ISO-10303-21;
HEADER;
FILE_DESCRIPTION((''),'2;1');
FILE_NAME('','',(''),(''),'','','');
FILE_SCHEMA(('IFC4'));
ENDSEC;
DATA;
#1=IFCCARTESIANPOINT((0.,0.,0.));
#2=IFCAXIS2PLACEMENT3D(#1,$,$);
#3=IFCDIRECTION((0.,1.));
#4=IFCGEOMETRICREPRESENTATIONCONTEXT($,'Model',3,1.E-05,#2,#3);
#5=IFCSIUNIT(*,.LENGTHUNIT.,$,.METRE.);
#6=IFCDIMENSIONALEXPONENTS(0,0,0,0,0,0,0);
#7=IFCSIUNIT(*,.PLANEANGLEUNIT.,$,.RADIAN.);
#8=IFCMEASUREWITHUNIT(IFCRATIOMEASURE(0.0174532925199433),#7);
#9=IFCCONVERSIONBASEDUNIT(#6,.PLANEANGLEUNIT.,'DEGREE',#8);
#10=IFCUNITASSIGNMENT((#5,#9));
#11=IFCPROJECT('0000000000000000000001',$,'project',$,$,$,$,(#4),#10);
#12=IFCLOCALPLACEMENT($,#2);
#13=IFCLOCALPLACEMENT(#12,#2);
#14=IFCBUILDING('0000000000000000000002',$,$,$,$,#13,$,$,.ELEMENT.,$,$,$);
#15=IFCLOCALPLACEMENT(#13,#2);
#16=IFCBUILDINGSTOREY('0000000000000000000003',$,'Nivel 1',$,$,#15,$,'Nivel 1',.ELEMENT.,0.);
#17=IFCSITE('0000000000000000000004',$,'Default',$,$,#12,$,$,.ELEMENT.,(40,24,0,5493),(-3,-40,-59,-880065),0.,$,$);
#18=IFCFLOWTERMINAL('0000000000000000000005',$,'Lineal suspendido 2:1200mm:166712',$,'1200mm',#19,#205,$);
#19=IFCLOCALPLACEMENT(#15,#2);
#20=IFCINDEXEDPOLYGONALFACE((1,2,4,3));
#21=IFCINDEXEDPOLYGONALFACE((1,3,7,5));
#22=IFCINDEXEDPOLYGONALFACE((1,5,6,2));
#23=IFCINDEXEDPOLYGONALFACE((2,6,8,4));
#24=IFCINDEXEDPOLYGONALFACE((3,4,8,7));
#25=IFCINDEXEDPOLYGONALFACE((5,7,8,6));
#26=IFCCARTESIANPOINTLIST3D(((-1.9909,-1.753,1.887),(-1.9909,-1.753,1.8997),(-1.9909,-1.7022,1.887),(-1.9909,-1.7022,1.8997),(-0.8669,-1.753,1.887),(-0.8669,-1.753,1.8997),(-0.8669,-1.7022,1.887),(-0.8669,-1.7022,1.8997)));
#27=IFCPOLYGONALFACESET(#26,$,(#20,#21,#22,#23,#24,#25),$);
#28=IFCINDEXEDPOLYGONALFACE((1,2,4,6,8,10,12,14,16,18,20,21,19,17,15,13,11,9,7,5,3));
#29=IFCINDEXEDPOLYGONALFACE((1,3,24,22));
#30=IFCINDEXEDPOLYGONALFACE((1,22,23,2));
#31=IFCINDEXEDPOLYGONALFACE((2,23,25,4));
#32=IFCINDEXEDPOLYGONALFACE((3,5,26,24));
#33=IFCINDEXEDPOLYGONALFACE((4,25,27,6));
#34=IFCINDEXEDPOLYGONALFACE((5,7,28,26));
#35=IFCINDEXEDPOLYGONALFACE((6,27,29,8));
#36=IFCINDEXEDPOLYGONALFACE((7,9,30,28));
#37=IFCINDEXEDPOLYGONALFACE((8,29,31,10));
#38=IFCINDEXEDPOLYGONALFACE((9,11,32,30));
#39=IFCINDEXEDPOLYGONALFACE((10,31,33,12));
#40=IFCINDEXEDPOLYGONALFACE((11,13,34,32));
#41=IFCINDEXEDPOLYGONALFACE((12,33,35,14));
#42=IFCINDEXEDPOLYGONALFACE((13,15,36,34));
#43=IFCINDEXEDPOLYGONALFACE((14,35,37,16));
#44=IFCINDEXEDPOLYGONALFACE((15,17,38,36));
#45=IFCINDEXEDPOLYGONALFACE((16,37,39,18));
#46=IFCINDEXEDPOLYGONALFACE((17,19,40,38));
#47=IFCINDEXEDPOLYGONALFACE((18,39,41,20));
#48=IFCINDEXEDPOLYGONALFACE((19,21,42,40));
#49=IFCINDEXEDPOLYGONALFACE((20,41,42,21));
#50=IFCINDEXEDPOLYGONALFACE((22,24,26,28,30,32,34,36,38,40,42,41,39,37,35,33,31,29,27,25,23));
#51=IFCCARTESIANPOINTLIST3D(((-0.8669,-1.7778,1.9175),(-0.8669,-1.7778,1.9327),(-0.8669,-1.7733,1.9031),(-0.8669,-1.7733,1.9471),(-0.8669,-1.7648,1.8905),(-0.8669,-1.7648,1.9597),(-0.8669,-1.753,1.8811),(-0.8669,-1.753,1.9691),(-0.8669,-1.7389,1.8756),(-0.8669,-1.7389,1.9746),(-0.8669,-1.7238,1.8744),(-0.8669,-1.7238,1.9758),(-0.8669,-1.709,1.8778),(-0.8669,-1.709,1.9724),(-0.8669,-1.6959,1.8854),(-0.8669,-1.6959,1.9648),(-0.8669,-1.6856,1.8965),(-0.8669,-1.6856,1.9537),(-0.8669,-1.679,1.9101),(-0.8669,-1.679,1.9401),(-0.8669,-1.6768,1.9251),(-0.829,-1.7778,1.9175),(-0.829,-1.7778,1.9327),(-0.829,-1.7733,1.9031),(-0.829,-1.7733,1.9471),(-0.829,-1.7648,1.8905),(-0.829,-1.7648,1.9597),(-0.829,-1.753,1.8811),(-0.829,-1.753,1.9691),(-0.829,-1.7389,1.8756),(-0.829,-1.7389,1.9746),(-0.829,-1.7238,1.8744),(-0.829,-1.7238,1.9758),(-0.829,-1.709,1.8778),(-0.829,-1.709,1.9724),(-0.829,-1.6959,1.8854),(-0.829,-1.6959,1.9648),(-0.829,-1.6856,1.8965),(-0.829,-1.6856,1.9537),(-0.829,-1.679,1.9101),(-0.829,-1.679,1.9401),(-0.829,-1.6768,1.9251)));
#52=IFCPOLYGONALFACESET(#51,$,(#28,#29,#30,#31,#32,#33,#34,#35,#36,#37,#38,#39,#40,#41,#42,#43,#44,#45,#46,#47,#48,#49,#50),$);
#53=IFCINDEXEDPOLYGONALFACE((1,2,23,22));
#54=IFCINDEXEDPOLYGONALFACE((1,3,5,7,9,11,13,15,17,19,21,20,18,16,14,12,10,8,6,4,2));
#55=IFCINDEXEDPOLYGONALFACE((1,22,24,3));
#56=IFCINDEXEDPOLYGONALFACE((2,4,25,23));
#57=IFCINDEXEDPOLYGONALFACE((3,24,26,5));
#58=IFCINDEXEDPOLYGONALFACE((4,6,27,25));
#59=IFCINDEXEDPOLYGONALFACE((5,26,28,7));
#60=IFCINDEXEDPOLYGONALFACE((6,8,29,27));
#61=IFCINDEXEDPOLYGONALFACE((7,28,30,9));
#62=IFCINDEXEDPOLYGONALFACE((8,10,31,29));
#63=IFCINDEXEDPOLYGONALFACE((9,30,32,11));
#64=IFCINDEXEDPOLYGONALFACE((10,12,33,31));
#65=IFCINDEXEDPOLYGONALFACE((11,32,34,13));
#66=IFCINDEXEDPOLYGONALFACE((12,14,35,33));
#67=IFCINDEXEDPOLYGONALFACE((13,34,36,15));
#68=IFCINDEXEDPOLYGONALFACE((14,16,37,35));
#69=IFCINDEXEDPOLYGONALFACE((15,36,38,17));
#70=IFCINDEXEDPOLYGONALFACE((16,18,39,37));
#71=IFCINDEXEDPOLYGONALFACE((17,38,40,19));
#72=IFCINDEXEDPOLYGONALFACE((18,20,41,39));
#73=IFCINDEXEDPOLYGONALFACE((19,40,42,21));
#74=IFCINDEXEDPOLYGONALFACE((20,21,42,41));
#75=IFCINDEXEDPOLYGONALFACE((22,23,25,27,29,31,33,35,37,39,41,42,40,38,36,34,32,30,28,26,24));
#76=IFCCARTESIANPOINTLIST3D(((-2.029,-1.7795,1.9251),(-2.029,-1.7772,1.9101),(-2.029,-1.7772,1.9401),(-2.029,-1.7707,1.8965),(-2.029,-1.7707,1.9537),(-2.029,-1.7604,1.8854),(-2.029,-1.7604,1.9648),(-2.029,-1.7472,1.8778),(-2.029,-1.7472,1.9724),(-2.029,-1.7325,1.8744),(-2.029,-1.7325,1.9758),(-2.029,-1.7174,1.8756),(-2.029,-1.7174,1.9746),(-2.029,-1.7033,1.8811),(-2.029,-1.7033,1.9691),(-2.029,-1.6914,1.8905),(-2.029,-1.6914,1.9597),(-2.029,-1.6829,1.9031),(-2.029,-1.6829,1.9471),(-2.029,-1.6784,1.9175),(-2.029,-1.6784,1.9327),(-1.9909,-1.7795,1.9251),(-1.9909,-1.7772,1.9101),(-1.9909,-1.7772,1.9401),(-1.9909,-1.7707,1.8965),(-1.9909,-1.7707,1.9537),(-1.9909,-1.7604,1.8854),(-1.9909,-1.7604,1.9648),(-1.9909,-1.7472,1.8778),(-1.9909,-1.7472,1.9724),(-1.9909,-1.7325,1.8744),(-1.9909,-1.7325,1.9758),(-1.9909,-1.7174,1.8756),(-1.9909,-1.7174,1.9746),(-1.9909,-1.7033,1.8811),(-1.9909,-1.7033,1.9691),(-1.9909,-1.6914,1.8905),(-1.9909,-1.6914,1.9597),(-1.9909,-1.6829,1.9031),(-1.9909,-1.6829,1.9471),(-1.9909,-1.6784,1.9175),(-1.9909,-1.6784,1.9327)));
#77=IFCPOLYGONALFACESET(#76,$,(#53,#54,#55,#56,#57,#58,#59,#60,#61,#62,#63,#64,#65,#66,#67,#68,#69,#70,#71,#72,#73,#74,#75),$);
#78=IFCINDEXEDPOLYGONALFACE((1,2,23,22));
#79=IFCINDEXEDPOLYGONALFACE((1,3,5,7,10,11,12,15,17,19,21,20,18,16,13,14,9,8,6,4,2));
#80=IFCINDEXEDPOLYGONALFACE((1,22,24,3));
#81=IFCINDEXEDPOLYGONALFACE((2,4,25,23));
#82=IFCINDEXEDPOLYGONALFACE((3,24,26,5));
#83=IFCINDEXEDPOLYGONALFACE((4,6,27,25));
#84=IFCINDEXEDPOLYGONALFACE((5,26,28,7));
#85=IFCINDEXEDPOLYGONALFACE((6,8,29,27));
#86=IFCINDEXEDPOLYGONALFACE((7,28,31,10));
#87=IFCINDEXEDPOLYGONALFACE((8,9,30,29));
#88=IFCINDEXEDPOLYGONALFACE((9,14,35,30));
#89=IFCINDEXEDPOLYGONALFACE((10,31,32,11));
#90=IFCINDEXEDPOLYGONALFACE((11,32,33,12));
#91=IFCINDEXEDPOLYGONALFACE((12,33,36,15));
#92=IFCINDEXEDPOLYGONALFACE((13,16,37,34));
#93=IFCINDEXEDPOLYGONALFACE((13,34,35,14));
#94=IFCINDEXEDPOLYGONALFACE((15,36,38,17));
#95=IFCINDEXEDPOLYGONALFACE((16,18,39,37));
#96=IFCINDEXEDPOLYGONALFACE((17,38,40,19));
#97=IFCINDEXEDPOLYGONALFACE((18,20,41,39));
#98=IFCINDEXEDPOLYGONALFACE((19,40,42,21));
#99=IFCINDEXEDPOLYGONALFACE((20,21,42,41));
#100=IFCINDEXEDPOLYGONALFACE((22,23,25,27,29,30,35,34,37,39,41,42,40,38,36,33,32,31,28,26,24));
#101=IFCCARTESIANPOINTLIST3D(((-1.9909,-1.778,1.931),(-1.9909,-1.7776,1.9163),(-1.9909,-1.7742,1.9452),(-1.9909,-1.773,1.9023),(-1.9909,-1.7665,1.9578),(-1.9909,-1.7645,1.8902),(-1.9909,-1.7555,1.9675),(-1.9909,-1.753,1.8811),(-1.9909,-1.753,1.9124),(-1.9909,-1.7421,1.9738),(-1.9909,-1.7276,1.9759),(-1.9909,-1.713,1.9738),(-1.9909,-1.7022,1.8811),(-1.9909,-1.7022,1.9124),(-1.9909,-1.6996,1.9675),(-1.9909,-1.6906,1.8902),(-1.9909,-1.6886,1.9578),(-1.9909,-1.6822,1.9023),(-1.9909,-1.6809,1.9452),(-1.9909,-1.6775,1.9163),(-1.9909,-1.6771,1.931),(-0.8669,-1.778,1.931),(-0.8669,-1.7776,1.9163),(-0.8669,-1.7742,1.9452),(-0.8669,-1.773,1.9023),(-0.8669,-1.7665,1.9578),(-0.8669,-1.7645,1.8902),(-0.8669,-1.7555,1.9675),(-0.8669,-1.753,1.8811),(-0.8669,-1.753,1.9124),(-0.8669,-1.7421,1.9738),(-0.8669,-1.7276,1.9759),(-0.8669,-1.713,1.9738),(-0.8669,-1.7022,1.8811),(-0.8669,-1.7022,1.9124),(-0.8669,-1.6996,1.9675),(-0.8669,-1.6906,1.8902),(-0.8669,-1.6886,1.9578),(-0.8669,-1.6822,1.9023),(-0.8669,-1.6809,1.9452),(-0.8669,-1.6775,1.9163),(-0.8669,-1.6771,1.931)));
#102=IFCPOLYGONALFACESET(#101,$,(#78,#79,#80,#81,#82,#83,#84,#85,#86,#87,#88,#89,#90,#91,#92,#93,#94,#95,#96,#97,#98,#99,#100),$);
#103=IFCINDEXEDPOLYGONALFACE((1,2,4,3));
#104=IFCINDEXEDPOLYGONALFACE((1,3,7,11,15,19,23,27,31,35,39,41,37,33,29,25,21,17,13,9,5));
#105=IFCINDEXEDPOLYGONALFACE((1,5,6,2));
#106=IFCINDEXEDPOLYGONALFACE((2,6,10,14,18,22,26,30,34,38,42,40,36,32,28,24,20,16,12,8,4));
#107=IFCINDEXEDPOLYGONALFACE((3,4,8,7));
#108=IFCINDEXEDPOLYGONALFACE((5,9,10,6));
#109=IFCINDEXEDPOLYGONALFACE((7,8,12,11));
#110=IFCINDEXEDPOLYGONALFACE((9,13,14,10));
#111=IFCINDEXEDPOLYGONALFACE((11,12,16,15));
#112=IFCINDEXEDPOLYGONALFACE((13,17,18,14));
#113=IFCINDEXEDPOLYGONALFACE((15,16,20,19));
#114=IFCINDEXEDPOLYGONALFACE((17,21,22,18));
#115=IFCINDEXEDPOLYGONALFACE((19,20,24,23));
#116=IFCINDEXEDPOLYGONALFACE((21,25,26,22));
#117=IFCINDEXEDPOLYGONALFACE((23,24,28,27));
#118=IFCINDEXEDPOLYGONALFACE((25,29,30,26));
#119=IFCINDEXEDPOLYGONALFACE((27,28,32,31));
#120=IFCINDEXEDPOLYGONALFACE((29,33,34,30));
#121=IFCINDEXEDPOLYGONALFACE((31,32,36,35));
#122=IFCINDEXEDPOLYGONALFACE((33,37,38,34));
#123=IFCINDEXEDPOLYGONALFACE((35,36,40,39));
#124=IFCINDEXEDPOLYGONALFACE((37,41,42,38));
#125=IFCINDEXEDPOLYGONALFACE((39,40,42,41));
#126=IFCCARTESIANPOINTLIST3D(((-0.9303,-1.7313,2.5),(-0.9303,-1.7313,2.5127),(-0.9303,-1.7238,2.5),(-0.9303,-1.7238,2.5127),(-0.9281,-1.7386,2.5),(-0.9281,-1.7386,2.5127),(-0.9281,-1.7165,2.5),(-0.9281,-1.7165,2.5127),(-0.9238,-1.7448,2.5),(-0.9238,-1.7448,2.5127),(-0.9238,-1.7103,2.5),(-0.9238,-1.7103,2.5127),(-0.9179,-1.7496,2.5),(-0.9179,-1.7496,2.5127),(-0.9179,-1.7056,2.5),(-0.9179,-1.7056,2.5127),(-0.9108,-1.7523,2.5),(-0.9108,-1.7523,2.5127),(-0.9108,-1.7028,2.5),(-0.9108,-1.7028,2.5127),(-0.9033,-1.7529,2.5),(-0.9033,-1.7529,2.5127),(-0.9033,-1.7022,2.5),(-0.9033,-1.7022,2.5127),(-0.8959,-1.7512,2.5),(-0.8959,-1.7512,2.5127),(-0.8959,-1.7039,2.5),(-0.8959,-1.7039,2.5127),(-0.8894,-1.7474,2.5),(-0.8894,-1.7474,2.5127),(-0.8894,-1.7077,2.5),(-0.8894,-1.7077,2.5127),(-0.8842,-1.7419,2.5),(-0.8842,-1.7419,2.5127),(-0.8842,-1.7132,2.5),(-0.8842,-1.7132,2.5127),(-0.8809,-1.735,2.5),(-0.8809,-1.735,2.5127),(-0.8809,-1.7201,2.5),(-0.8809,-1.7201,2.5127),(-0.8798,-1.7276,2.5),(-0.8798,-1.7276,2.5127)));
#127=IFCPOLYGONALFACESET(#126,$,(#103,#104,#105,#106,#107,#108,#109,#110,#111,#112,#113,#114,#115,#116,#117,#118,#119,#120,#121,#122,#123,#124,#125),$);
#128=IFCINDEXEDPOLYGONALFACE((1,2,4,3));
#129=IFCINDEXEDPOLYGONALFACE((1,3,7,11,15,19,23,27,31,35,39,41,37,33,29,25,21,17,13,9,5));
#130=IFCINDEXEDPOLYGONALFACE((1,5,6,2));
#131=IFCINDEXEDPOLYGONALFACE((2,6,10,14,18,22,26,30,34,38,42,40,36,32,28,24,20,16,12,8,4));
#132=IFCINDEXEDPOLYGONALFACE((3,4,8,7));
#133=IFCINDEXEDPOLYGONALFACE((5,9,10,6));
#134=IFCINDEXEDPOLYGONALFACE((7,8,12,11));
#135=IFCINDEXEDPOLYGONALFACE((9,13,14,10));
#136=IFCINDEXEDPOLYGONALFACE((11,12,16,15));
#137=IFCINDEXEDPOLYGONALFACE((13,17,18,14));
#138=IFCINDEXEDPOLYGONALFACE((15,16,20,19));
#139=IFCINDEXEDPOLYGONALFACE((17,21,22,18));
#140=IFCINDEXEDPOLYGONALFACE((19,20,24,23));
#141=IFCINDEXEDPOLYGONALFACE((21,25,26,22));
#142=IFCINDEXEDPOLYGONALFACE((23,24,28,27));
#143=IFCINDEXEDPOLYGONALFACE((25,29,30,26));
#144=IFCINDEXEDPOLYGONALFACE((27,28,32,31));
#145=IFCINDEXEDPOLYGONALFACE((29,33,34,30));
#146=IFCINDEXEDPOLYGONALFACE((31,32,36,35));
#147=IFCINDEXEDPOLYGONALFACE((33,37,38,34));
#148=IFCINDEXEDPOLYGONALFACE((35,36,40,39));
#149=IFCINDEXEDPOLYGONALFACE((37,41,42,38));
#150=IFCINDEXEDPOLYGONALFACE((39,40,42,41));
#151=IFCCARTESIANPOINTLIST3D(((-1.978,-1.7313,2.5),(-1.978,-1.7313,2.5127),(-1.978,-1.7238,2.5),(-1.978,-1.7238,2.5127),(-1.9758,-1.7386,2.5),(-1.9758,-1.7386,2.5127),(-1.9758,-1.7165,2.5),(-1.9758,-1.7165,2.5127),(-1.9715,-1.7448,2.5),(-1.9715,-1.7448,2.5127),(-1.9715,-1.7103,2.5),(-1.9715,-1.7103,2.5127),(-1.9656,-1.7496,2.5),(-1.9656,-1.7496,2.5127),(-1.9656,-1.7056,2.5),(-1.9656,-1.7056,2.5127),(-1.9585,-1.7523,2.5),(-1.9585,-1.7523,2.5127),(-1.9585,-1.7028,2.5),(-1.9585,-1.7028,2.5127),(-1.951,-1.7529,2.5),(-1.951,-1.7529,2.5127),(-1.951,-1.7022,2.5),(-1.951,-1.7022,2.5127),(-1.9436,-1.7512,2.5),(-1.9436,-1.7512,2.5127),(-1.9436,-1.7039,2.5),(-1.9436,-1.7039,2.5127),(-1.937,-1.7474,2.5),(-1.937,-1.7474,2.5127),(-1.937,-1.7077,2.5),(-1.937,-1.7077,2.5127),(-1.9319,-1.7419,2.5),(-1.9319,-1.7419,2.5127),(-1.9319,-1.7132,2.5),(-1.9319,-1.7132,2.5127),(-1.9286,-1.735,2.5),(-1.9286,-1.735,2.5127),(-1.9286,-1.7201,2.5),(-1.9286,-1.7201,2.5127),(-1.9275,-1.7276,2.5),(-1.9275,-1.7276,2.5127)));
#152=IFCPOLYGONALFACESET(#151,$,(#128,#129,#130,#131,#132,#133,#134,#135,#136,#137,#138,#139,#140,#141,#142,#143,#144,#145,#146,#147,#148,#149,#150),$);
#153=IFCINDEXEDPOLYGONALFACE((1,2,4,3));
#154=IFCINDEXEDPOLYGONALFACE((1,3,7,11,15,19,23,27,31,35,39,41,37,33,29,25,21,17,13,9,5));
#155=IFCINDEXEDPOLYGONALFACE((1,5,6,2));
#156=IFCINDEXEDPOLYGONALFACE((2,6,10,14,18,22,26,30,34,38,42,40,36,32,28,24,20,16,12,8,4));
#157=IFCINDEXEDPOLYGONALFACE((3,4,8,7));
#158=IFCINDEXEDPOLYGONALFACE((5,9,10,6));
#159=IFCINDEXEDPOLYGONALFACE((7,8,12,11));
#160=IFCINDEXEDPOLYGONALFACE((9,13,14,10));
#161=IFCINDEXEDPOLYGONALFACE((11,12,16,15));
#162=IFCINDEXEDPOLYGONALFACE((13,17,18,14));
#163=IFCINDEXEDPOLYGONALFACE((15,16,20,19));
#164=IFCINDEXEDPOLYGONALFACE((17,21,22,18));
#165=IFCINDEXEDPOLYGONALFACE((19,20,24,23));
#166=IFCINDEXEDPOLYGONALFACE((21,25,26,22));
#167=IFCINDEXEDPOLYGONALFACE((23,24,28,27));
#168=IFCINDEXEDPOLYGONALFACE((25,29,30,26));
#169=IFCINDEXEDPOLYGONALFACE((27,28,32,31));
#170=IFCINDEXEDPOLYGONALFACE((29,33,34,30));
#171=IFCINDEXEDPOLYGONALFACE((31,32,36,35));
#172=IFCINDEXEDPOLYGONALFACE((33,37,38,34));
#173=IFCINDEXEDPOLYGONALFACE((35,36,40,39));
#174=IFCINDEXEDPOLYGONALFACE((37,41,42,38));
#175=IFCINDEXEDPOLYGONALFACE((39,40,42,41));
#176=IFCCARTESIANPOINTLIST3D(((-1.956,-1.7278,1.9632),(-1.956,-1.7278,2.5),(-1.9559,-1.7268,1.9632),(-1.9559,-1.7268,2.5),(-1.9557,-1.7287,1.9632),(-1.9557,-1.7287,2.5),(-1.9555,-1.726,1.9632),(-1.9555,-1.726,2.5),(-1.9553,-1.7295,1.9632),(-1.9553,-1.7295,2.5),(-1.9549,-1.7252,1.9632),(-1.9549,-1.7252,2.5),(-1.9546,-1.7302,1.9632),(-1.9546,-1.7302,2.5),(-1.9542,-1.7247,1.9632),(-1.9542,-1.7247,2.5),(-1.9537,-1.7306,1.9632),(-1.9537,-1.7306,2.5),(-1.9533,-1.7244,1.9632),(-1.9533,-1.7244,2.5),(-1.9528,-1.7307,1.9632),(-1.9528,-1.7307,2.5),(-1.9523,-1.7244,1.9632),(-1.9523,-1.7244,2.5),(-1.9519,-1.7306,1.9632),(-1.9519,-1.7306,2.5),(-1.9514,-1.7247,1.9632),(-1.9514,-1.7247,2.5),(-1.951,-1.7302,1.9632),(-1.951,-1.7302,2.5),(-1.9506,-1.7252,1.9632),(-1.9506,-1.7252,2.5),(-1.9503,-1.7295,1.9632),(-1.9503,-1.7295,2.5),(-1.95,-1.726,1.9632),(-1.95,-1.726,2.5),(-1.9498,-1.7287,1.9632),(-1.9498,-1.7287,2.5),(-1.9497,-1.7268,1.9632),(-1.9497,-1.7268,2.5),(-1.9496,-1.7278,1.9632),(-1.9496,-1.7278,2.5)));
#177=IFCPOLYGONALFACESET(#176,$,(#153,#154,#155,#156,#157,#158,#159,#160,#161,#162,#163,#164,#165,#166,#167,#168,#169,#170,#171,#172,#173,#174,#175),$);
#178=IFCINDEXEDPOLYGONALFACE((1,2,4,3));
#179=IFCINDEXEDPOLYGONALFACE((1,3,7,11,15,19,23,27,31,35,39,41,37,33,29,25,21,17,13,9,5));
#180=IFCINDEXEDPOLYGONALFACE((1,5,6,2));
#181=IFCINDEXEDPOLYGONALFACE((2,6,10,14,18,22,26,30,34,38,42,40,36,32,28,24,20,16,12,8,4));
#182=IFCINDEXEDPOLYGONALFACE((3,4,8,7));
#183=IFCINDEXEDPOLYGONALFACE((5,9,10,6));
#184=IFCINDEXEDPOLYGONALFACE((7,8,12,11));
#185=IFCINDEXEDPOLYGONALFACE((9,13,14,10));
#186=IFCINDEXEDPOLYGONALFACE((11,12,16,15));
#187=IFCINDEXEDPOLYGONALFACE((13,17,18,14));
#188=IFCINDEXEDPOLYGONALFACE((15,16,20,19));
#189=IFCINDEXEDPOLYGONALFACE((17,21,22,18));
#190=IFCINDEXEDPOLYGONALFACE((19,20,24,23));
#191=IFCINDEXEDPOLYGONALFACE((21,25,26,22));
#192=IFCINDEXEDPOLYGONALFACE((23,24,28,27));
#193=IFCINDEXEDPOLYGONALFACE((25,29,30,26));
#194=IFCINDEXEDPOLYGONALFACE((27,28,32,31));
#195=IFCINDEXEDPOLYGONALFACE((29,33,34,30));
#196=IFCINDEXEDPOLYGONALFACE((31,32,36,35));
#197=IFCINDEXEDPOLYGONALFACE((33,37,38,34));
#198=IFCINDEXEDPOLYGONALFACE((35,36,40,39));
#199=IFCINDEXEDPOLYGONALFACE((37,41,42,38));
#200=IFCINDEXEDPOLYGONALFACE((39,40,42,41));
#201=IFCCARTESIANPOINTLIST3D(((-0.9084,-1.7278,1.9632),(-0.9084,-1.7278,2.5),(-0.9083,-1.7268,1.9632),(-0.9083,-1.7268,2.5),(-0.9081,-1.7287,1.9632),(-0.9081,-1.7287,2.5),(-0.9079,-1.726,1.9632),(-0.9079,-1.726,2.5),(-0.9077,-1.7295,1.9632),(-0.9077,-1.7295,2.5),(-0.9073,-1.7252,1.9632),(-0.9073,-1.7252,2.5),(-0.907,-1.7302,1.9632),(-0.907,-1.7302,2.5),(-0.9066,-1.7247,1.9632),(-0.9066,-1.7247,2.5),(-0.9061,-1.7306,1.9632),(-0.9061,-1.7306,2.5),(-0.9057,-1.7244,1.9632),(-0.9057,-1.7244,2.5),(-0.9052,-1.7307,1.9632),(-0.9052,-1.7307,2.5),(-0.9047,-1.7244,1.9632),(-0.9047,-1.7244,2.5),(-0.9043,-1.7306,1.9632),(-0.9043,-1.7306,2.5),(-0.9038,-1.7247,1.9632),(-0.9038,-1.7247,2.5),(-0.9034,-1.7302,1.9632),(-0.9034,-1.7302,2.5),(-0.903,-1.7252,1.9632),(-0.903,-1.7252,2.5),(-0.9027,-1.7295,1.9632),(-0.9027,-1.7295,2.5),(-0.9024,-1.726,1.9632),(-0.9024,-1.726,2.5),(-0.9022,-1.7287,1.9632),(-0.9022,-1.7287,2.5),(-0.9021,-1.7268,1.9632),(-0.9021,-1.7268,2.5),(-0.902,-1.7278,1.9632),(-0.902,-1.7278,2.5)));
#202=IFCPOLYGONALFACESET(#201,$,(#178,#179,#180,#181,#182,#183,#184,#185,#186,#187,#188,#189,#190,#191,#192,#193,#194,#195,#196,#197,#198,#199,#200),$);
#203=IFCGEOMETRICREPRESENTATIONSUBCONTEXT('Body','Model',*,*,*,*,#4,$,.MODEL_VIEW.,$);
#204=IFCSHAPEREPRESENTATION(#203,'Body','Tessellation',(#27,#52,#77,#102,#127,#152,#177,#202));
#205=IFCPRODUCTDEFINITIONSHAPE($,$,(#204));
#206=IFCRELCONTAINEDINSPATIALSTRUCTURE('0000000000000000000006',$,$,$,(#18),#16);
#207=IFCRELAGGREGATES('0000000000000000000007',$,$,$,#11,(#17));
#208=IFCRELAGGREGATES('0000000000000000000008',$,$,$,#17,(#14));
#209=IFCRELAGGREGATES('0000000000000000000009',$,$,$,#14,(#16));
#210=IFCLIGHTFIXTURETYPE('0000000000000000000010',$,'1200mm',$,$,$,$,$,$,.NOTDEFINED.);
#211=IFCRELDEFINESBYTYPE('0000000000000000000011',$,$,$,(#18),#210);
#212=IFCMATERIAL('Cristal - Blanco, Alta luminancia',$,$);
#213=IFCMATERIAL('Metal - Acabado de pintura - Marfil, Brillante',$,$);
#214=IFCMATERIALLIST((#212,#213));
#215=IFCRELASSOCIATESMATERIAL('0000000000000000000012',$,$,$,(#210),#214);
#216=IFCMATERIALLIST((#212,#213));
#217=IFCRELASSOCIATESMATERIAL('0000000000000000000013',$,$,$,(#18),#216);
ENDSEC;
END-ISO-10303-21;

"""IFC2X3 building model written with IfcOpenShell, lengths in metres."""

from ifc_helpers import new_model, entity, si_unit, converted_unit, direction, frame, frame_2d, origin, origin_2d_with_axis, place, context, subcontext, project, spatial, polyline, circle_curve, parameter, trimmed, segment, composite_curve, rectangle, circle, outline, extrude, source, transform, mapped, material, material_list, type_object, type_shapes, element, save


model = new_model("IFC2X3")

# Units and contexts
model_context = context("Model", 3, precision=1e-05, world=origin(), true_north=direction((0.0, 1.0)))
body_context = subcontext(model_context, "Body", "Model", "MODEL_VIEW")
ifc_project = project(units=[si_unit("LENGTHUNIT", "METRE"), converted_unit("PLANEANGLEUNIT", "DEGREE", entity("IfcRatioMeasure", 0.0174532925199433), si_unit("PLANEANGLEUNIT", "RADIAN"), dimensions=[0, 0, 0, 0, 0, 0, 0])], contexts=[model_context])

# Site, building, storey
site_placement = place(None, origin())
site = spatial("IfcSite", under=ifc_project, at=site_placement, Name="Default", CompositionType="ELEMENT", RefLatitude=(40, 24, 0, 5493), RefLongitude=(-3, -40, -59, -880065), RefElevation=0.0)
building_placement = place(site_placement, origin())
building = spatial("IfcBuilding", under=site, at=building_placement, CompositionType="ELEMENT")
storey_placement = place(building_placement, origin())
storey = spatial("IfcBuildingStorey", under=building, at=storey_placement, Name="Nivel 1", LongName="Nivel 1", CompositionType="ELEMENT", Elevation=0.0)

# Flow terminal
ifc_material_1 = material(Name="Cristal - Blanco, Alta luminancia")
ifc_material_2 = material(Name="Metal - Acabado de pintura - Marfil, Brillante")
ifc_material_list_1 = material_list([ifc_material_1, ifc_material_2])
light_fixture_type = type_object("IfcLightFixtureType", Name="1200mm", PredefinedType="NOTDEFINED", material=ifc_material_list_1)
shared_shape = source(origin(), body_context, "Body", "SweptSolid", [
    extrude(rectangle(XDim=1.124, YDim=0.0508, at=origin_2d_with_axis()), frame((0.0001, 0.0, 1.8127), z_axis=(0.0, 0.0, 1.0), x_axis=(-1.0, 0.0, 0.0)), (0.0, 0.0, 1.0), 0.0127),
    extrude(circle(Radius=0.0508, at=frame_2d((0.0, 0.0), x_axis=(1.0, 0.0))), frame((0.5621, 0.0, 1.8508), z_axis=(1.0, 0.0, 0.0), x_axis=(0.0, 1.0, 0.0)), (0.0, 0.0, 1.0), 0.0379),
    extrude(circle(Radius=0.0508, at=frame_2d((0.0, 0.0), x_axis=(1.0, 0.0))), frame((-0.6, -0.0011, 1.8508), z_axis=(1.0, 0.0, 0.0), x_axis=(0.0, -1.0, 0.0)), (0.0, 0.0, 1.0), 0.0381),
    extrude(outline(composite_curve([segment(trimmed(circle_curve(frame_2d((0.0125, 0.0), x_axis=(0.0, 1.0)), 0.0508), [parameter(120.0)], [parameter(270.0)], True, "PARAMETER"), True, "CONTINUOUS"), segment(trimmed(circle_curve(frame_2d((0.0125, 0.0), x_axis=(0.0, 1.0)), 0.0508), [parameter(270.0)], [parameter(60.0)], True, "PARAMETER"), True, "CONTINUOUS"), segment(polyline([(-0.0315, 0.0254), (-0.0002, 0.0254)]), True, "CONTINUOUS"), segment(polyline([(-0.0002, 0.0254), (-0.0002, -0.0254)]), True, "CONTINUOUS"), segment(polyline([(-0.0002, -0.0254), (-0.0315, -0.0254)]), True, "CONTINUOUS")], self_intersect=False)), frame((-0.5619, 0.0, 1.8383), z_axis=(-1.0, 0.0, 0.0), x_axis=(0.0, 0.0, 1.0)), (0.0, 0.0, -1.0), 1.124),
    extrude(circle(Radius=0.0254, at=frame_2d((0.0, 0.0), x_axis=(1.0, 0.0))), frame((0.5238, 0.0, 2.4257)), (0.0, 0.0, 1.0), 0.0127),
    extrude(circle(Radius=0.0254, at=frame_2d((0.0, 0.0), x_axis=(1.0, 0.0))), frame((-0.5239, 0.0, 2.4257)), (0.0, 0.0, 1.0), 0.0127),
    extrude(circle(Radius=0.0032, at=frame_2d((0.0, 0.0), x_axis=(1.0, 0.0))), frame((-0.5238, 0.0, 1.8889), z_axis=(0.0, 0.0, 1.0), x_axis=(0.0, -1.0, 0.0)), (0.0, 0.0, 1.0), 0.5368),
    extrude(circle(Radius=0.0032, at=frame_2d((0.0, 0.0), x_axis=(1.0, 0.0))), frame((0.5238, 0.0, 1.8889), z_axis=(0.0, 0.0, 1.0), x_axis=(0.0, -1.0, 0.0)), (0.0, 0.0, 1.0), 0.5368),
])
type_shapes(light_fixture_type, [shared_shape])
ifc_material_list_2 = material_list([ifc_material_1, ifc_material_2])
flow_terminal_1_placement = place(storey_placement, frame((-1.429, -1.7276, 0.0743)))
element("IfcFlowTerminal", 1, at=flow_terminal_1_placement, inside=storey, type_object=light_fixture_type, material=ifc_material_list_2, Name="Lineal suspendido 2:1200mm:166712", ObjectType="1200mm", context=body_context, shape_type="MappedRepresentation", body=[
    mapped(shared_shape, transform((0.0, 0.0, 0.0), scale=1.0)),
])

save(model, "model.ifc")
